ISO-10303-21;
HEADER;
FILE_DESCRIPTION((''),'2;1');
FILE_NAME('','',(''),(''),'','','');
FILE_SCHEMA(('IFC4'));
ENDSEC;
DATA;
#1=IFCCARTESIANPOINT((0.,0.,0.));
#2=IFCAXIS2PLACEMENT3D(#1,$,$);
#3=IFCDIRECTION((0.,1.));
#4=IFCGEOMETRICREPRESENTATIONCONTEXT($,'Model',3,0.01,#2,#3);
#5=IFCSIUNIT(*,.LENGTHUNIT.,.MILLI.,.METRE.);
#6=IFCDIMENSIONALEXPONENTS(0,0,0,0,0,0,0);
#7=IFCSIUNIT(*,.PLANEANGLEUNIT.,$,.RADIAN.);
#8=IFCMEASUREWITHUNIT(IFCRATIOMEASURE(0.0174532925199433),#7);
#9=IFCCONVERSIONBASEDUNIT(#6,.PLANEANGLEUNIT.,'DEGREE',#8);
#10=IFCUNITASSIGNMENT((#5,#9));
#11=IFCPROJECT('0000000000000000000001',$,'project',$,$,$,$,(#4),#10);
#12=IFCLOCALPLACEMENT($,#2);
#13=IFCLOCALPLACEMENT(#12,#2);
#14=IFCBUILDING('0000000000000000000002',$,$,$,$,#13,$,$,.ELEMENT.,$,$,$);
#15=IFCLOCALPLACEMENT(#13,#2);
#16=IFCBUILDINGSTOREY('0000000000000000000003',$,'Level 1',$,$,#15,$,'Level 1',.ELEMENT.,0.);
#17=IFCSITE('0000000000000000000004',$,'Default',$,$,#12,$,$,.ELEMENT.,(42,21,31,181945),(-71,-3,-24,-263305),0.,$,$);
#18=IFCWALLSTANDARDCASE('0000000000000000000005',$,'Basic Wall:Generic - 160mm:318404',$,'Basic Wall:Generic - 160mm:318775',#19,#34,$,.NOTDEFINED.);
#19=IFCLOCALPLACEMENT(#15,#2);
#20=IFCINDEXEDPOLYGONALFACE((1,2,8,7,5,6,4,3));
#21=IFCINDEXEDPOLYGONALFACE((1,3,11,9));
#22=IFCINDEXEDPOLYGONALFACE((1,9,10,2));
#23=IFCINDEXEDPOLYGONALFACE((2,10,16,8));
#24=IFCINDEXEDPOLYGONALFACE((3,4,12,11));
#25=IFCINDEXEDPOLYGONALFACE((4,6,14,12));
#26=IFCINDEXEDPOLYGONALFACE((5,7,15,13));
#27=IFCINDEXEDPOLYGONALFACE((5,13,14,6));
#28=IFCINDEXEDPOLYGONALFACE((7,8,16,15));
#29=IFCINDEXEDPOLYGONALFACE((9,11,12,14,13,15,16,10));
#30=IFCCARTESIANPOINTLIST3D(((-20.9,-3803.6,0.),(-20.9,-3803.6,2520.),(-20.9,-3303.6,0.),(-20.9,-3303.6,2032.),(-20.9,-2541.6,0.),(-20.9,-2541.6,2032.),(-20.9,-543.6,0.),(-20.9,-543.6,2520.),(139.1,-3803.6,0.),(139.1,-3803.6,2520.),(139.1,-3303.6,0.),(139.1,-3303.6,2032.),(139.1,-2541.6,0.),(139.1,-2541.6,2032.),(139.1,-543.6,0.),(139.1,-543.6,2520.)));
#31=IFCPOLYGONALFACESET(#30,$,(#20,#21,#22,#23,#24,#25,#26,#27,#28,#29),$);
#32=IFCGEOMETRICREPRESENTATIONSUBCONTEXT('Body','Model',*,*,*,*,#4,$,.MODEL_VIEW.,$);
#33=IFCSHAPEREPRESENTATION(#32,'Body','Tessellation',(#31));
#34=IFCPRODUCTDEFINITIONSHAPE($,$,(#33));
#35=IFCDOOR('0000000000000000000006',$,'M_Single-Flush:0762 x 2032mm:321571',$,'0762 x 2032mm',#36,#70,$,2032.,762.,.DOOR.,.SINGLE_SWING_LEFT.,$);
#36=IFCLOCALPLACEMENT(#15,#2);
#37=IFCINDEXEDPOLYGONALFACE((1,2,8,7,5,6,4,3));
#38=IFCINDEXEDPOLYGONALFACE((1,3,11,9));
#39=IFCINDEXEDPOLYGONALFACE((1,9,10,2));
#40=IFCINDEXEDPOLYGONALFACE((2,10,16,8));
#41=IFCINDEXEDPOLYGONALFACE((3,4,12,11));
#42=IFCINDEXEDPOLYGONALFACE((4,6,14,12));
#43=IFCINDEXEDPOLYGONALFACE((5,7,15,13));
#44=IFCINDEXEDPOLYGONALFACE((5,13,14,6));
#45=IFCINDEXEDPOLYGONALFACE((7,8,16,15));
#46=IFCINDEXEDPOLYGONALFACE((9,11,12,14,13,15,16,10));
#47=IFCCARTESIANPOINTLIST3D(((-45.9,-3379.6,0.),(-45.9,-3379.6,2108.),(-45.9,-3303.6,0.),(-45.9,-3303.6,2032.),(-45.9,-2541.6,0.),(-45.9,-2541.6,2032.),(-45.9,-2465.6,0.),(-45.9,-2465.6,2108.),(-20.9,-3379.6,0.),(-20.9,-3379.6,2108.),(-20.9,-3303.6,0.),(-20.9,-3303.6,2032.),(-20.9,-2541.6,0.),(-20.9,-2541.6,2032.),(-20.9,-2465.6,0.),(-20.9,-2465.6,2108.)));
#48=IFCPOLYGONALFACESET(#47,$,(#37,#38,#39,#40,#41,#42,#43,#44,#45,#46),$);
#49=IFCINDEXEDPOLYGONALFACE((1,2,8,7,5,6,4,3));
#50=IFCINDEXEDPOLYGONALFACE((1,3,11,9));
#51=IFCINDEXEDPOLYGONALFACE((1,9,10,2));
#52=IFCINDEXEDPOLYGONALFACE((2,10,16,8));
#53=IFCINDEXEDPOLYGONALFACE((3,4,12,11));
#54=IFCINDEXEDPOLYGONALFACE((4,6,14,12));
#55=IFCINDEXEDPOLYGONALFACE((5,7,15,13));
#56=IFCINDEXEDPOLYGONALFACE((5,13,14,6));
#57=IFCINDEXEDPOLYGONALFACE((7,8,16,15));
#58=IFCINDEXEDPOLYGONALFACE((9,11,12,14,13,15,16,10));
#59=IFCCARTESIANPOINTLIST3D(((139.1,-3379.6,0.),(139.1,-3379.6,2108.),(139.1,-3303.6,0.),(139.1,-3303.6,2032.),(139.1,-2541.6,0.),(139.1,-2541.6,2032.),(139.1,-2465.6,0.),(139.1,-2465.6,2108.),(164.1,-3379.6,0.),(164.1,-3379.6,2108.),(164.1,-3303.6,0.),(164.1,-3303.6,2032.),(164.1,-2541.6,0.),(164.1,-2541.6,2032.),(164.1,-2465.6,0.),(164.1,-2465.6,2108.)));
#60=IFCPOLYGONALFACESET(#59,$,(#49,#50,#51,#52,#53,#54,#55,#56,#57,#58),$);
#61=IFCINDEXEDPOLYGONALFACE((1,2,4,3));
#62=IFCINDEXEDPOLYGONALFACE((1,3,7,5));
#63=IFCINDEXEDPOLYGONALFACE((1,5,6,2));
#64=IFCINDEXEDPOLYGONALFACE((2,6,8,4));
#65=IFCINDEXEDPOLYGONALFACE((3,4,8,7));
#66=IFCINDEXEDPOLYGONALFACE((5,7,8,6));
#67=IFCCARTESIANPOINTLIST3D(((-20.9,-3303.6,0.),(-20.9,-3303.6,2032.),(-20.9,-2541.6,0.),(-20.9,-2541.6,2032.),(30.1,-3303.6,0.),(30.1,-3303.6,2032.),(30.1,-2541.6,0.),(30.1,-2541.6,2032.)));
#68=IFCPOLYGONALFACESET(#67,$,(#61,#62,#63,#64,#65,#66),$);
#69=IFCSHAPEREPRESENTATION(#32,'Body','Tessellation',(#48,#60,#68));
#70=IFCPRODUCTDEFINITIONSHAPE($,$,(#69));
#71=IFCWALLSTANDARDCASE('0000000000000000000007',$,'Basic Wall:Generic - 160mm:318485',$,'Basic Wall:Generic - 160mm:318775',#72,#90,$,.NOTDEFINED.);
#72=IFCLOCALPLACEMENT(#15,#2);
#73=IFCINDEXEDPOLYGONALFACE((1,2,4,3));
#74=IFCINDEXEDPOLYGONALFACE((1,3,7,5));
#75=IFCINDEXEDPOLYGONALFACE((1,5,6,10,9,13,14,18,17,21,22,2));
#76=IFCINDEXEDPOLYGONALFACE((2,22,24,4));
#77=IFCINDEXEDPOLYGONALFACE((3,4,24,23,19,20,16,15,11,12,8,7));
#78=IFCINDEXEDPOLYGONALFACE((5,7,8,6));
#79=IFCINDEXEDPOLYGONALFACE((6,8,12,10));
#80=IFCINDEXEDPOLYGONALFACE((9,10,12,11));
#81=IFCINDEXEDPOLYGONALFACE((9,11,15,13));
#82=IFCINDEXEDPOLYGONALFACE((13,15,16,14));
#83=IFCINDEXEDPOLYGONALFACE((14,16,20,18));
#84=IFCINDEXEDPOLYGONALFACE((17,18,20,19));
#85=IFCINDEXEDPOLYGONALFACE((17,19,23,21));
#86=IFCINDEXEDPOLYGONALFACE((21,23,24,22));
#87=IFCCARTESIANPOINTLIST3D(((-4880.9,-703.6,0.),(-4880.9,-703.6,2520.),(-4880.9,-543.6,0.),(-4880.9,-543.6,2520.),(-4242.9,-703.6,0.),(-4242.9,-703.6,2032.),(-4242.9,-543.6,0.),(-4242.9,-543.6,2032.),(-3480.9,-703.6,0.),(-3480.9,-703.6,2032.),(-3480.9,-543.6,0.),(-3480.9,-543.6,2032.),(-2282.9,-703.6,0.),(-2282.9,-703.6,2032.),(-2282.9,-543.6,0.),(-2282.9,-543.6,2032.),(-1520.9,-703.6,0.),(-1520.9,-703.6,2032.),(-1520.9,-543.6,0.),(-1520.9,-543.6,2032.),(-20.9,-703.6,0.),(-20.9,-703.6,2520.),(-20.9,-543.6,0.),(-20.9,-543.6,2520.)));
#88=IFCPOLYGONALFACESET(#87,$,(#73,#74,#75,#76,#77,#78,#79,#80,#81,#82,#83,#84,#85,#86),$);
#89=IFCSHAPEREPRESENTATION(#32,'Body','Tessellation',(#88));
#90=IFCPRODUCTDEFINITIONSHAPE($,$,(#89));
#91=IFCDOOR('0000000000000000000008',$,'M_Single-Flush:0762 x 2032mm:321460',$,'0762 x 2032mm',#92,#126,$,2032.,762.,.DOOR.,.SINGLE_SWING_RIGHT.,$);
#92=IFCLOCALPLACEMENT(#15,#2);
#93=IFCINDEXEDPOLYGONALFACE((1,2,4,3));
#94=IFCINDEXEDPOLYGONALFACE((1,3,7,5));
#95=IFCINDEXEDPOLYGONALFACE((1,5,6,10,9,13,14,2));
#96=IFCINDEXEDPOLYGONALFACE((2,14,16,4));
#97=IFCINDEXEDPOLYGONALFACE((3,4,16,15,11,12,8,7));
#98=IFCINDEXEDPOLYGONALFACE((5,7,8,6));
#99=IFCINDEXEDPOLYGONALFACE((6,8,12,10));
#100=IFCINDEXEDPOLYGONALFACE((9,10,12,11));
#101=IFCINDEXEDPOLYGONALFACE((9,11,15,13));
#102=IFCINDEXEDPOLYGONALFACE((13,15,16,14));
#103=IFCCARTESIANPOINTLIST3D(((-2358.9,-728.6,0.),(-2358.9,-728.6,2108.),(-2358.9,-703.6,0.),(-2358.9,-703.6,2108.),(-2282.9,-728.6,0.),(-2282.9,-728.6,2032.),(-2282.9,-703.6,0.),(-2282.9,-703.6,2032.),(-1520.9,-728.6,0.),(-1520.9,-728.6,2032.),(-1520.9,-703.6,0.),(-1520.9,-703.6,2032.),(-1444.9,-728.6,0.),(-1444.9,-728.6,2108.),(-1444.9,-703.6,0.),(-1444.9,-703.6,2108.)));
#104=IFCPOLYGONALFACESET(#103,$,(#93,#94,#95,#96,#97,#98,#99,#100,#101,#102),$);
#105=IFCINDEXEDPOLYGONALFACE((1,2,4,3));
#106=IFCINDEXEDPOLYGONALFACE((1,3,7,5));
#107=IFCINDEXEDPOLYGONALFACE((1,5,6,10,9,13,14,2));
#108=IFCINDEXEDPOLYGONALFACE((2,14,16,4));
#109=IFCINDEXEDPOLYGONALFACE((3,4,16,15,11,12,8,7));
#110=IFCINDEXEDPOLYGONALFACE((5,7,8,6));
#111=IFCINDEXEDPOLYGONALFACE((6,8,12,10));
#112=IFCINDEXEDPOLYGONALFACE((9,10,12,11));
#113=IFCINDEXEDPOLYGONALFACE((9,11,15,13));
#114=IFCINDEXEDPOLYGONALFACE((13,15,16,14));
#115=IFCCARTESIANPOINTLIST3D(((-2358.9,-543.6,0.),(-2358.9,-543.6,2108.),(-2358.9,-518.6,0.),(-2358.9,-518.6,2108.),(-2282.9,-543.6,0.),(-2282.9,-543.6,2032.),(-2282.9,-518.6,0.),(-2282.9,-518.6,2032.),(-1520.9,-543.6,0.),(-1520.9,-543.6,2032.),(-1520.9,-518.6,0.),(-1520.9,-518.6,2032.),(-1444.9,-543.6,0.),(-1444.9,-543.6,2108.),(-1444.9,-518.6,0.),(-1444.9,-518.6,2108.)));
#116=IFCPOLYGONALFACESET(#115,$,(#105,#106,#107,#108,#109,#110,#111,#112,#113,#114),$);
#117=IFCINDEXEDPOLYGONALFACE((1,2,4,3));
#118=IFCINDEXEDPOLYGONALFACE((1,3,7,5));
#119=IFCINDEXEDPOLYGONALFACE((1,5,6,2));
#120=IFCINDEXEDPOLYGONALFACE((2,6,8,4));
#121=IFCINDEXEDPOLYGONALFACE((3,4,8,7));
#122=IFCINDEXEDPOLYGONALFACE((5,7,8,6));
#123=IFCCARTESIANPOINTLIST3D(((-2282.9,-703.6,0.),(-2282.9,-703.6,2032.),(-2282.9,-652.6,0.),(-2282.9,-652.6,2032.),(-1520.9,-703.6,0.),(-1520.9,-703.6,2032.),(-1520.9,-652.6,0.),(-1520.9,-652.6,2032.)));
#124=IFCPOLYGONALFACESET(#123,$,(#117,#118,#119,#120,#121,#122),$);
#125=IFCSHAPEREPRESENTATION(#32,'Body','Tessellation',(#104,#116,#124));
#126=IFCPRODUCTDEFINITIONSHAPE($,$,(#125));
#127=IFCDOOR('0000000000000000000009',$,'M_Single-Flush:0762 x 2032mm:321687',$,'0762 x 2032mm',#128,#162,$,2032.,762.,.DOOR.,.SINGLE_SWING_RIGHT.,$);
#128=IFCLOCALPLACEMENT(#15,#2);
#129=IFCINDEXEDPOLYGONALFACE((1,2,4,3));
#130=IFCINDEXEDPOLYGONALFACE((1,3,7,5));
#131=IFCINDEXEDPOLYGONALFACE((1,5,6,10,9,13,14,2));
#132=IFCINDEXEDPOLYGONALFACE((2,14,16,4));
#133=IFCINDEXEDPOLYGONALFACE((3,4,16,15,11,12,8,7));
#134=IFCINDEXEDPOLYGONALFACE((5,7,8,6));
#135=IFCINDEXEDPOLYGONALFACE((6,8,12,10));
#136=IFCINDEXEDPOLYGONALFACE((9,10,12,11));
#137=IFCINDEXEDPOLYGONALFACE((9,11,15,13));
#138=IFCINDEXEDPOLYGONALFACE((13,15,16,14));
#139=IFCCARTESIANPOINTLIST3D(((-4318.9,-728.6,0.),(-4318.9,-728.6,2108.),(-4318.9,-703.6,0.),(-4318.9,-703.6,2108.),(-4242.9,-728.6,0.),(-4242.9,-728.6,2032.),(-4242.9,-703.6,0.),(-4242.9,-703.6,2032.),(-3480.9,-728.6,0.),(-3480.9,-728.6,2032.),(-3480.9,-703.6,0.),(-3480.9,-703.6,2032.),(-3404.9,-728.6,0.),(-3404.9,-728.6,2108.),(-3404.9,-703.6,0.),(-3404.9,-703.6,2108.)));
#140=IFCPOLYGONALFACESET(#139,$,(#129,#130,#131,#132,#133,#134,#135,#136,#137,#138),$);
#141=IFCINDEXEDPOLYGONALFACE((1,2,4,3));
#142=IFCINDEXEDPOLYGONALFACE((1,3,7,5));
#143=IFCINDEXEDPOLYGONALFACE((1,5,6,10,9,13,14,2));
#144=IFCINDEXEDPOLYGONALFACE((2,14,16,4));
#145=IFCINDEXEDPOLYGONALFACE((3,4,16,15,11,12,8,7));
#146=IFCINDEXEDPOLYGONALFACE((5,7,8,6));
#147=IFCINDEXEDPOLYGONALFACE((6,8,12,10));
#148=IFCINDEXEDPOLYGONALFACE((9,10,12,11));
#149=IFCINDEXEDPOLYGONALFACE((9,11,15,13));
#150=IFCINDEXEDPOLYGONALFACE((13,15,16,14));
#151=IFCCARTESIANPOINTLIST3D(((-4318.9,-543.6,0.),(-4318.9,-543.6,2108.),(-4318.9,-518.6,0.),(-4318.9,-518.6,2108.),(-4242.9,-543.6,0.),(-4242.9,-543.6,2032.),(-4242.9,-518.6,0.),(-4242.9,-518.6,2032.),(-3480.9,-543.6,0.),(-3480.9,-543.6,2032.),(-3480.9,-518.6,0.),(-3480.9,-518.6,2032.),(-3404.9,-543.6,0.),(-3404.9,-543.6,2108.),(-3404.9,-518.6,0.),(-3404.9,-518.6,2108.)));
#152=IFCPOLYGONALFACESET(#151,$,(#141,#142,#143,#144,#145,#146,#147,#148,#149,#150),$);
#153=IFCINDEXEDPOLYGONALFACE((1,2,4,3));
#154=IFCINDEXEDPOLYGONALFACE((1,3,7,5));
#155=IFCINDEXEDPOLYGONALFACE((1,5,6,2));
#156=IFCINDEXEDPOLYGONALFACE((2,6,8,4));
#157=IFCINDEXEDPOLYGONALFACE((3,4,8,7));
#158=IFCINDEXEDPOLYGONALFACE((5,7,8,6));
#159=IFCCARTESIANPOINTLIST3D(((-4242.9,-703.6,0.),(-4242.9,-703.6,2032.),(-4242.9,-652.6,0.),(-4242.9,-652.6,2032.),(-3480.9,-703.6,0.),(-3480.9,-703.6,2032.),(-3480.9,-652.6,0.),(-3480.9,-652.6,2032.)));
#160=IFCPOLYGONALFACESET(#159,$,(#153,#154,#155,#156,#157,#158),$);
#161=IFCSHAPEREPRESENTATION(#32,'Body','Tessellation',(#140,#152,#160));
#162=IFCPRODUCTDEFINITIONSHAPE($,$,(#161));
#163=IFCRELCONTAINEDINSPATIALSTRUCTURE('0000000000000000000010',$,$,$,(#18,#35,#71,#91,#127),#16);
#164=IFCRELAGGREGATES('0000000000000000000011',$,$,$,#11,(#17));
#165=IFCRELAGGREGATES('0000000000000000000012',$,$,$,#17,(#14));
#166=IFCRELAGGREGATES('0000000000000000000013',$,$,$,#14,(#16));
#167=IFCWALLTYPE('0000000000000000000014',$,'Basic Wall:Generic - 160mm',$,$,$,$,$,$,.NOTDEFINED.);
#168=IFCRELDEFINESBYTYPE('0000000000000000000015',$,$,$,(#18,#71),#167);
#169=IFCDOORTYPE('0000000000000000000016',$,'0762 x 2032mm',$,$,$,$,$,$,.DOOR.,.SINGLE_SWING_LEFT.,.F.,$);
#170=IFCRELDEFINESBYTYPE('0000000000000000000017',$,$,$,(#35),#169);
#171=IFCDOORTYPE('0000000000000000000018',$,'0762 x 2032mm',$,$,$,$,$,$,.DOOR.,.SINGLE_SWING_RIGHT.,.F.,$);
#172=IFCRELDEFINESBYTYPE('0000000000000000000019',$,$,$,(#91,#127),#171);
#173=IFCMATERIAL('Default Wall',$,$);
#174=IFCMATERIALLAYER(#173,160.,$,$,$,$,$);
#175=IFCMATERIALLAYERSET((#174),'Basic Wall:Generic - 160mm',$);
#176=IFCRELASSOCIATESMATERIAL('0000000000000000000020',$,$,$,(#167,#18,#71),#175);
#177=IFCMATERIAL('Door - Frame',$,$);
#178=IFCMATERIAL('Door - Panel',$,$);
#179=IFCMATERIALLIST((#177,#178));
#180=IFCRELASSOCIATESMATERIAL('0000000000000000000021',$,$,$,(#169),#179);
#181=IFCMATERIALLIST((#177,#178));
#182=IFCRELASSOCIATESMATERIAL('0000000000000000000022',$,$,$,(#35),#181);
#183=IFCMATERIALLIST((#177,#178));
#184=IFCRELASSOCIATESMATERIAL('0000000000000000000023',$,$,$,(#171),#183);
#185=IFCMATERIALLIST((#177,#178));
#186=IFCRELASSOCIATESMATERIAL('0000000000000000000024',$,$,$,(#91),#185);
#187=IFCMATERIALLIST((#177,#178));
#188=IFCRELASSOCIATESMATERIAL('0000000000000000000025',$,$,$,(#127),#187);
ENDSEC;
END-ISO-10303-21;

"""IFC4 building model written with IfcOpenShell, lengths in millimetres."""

from ifc_helpers import new_model, entity, si_unit, converted_unit, direction, frame, frame_2d, origin, place, context, subcontext, project, spatial, polyline, rectangle, outline, extrude, source, transform, mapped, material, material_list, layer, layer_set, layer_usage, type_object, type_shapes, element, fill, save


model = new_model("IFC4")

# Units and contexts
model_context = context("Model", 3, precision=0.01, world=origin(), true_north=direction((0.0, 1.0)))
body_context = subcontext(model_context, "Body", "Model", "MODEL_VIEW")
ifc_project = project(units=[si_unit("LENGTHUNIT", "METRE", prefix="MILLI"), converted_unit("PLANEANGLEUNIT", "DEGREE", entity("IfcRatioMeasure", 0.0174532925199433), si_unit("PLANEANGLEUNIT", "RADIAN"), dimensions=[0, 0, 0, 0, 0, 0, 0])], contexts=[model_context])

# Site, building, storey
site_placement = place(None, origin())
site = spatial("IfcSite", under=ifc_project, at=site_placement, Name="Default", CompositionType="ELEMENT", RefLatitude=(42, 21, 31, 181945), RefLongitude=(-71, -3, -24, -263305), RefElevation=0.0)
building_placement = place(site_placement, origin())
building = spatial("IfcBuilding", under=site, at=building_placement, CompositionType="ELEMENT")
storey_placement = place(building_placement, origin())
storey = spatial("IfcBuildingStorey", under=building, at=storey_placement, Name="Level 1", LongName="Level 1", CompositionType="ELEMENT", Elevation=0.0)

# Shared definitions
ifc_material_1 = material(Name="Default Wall")

# Shared definitions
ifc_layer_1 = layer(ifc_material_1, 160.0)
ifc_layer_set_1 = layer_set([ifc_layer_1], Name="Basic Wall:Generic - 160mm")
wall_type_1 = type_object("IfcWallType", Name="Basic Wall:Generic - 160mm", PredefinedType="NOTDEFINED", material=ifc_layer_set_1)

# Wall, opening, door
ifc_layer_usage_1 = layer_usage(ifc_layer_set_1, "AXIS2", "POSITIVE", -80.0)
wall_1_placement = place(storey_placement, frame((59.1, -3803.6, 0.0), z_axis=(0.0, 0.0, 1.0), x_axis=(0.0, 1.0, 0.0)))
wall_1 = element("IfcWallStandardCase", 1, at=wall_1_placement, inside=storey, type_object=wall_type_1, material=ifc_layer_usage_1, Name="Basic Wall:Generic - 160mm:318404", ObjectType="Basic Wall:Generic - 160mm:318775", PredefinedType="NOTDEFINED", context=body_context, shape_type="SweptSolid", body=[
    extrude(rectangle(XDim=3260.0, YDim=160.0, at=frame_2d((1630.0, 0.0), x_axis=(-1.0, 0.0))), origin(), (0.0, 0.0, 1.0), 2520.0),
])
opening_1_placement = place(wall_1_placement, frame((500.0, -80.0, 0.0)))
opening_1 = element("IfcOpeningElement", 2, at=opening_1_placement, cuts=wall_1, ObjectType="Opening", PredefinedType="OPENING", context=body_context, shape_type="SweptSolid", body=[
    extrude(rectangle(XDim=762.0, YDim=2032.0, at=frame_2d((1016.0, 381.0), x_axis=(0.0, -1.0))), frame((0.0, 0.0, 0.0), z_axis=(0.0, 1.0, 0.0), x_axis=(0.0, 0.0, 1.0)), (0.0, 0.0, 1.0), 160.0),
])
ifc_material_2 = material(Name="Door - Frame")
ifc_material_3 = material(Name="Door - Panel")
ifc_material_list_1 = material_list([ifc_material_2, ifc_material_3])
ifc_material_list_2 = material_list([ifc_material_2, ifc_material_3])
door_type_1 = type_object("IfcDoorType", Name="0762 x 2032mm", OperationType="SINGLE_SWING_LEFT", ParameterTakesPrecedence=False, PredefinedType="DOOR", material=ifc_material_list_2)
shared_shape_1 = source(origin(), body_context, "Body", "SweptSolid", [
    extrude(outline(polyline([(-457.0, -1073.0), (457.0, -1073.0), (457.0, 1035.0), (381.0, 1035.0), (381.0, -997.0), (-381.0, -997.0), (-381.0, 1035.0), (-457.0, 1035.0), (-457.0, -1073.0)])), frame((381.0, 185.0, 1035.0), z_axis=(0.0, -1.0, 0.0), x_axis=(-1.0, 0.0, 0.0)), (0.0, 0.0, 1.0), 25.0),
    extrude(outline(polyline([(-1073.0, -457.0), (1035.0, -457.0), (1035.0, -381.0), (-997.0, -381.0), (-997.0, 381.0), (1035.0, 381.0), (1035.0, 457.0), (-1073.0, 457.0), (-1073.0, -457.0)])), frame((381.0, 0.0, 1035.0), z_axis=(0.0, -1.0, 0.0), x_axis=(0.0, 0.0, -1.0)), (0.0, 0.0, 1.0), 25.0),
    extrude(rectangle(XDim=762.0, YDim=51.0, at=frame_2d((0.0, 0.0), x_axis=(1.0, 0.0))), frame((381.0, 134.5, 0.0)), (0.0, 0.0, 1.0), 2032.0),
])
type_shapes(door_type_1, [shared_shape_1])
door_1_placement = place(opening_1_placement, origin())
door_1 = element("IfcDoor", 3, at=door_1_placement, inside=storey, type_object=door_type_1, material=ifc_material_list_1, Name="M_Single-Flush:0762 x 2032mm:321571", ObjectType="0762 x 2032mm", OperationType="SINGLE_SWING_LEFT", OverallHeight=2032.0, OverallWidth=762.0, PredefinedType="DOOR", context=body_context, shape_type="MappedRepresentation", body=[
    mapped(shared_shape_1, transform((0.0, 0.0, 0.0), scale=1.0)),
])
fill(opening_1, door_1)

# Wall, openings, doors
ifc_layer_usage_2 = layer_usage(ifc_layer_set_1, "AXIS2", "POSITIVE", -80.0)
wall_2_placement = place(storey_placement, frame((-20.9, -623.6, 0.0), z_axis=(0.0, 0.0, 1.0), x_axis=(-1.0, 0.0, 0.0)))
wall_2 = element("IfcWallStandardCase", 4, at=wall_2_placement, inside=storey, type_object=wall_type_1, material=ifc_layer_usage_2, Name="Basic Wall:Generic - 160mm:318485", ObjectType="Basic Wall:Generic - 160mm:318775", PredefinedType="NOTDEFINED", context=body_context, shape_type="SweptSolid", body=[
    extrude(rectangle(XDim=4860.0, YDim=160.0, at=frame_2d((2430.0, 0.0), x_axis=(-1.0, 0.0))), origin(), (0.0, 0.0, 1.0), 2520.0),
])
opening_2_placement = place(wall_2_placement, frame((1500.0, -80.0, 0.0)))
opening_2 = element("IfcOpeningElement", 5, at=opening_2_placement, cuts=wall_2, ObjectType="Opening", PredefinedType="OPENING", context=body_context, shape_type="SweptSolid", body=[
    extrude(rectangle(XDim=762.0, YDim=2032.0, at=frame_2d((1016.0, 381.0), x_axis=(0.0, 1.0))), frame((0.0, 0.0, 0.0), z_axis=(0.0, 1.0, 0.0), x_axis=(0.0, 0.0, 1.0)), (0.0, 0.0, 1.0), 160.0),
])
opening_3_placement = place(wall_2_placement, frame((3460.0, -80.0, 0.0)))
opening_3 = element("IfcOpeningElement", 6, at=opening_3_placement, cuts=wall_2, ObjectType="Opening", PredefinedType="OPENING", context=body_context, shape_type="SweptSolid", body=[
    extrude(rectangle(XDim=762.0, YDim=2032.0, at=frame_2d((1016.0, 381.0), x_axis=(0.0, 1.0))), frame((0.0, 0.0, 0.0), z_axis=(0.0, 1.0, 0.0), x_axis=(0.0, 0.0, 1.0)), (0.0, 0.0, 1.0), 160.0),
])
ifc_material_list_3 = material_list([ifc_material_2, ifc_material_3])
ifc_material_list_4 = material_list([ifc_material_2, ifc_material_3])
door_type_2 = type_object("IfcDoorType", Name="0762 x 2032mm", OperationType="SINGLE_SWING_RIGHT", ParameterTakesPrecedence=False, PredefinedType="DOOR", material=ifc_material_list_4)
shared_shape_2 = source(origin(), body_context, "Body", "SweptSolid", [
    extrude(outline(polyline([(-457.0, -1073.0), (457.0, -1073.0), (457.0, 1035.0), (381.0, 1035.0), (381.0, -997.0), (-381.0, -997.0), (-381.0, 1035.0), (-457.0, 1035.0), (-457.0, -1073.0)])), frame((381.0, 160.0, 1035.0), z_axis=(0.0, 1.0, 0.0), x_axis=(1.0, 0.0, 0.0)), (0.0, 0.0, 1.0), 25.0),
    extrude(outline(polyline([(-1073.0, -457.0), (1035.0, -457.0), (1035.0, -381.0), (-997.0, -381.0), (-997.0, 381.0), (1035.0, 381.0), (1035.0, 457.0), (-1073.0, 457.0), (-1073.0, -457.0)])), frame((381.0, -25.0, 1035.0), z_axis=(0.0, 1.0, 0.0), x_axis=(0.0, 0.0, -1.0)), (0.0, 0.0, 1.0), 25.0),
    extrude(rectangle(XDim=51.0, YDim=762.0, at=frame_2d((0.0, 0.0), x_axis=(1.0, 0.0))), frame((381.0, 134.5, 0.0), z_axis=(0.0, 0.0, 1.0), x_axis=(0.0, 1.0, 0.0)), (0.0, 0.0, 1.0), 2032.0),
])
type_shapes(door_type_2, [shared_shape_2])
door_2_placement = place(opening_2_placement, origin())
door_2 = element("IfcDoor", 7, at=door_2_placement, inside=storey, type_object=door_type_2, material=ifc_material_list_3, Name="M_Single-Flush:0762 x 2032mm:321460", ObjectType="0762 x 2032mm", OperationType="SINGLE_SWING_RIGHT", OverallHeight=2032.0, OverallWidth=762.0, PredefinedType="DOOR", context=body_context, shape_type="MappedRepresentation", body=[
    mapped(shared_shape_2, transform((0.0, 0.0, 0.0), scale=1.0)),
])
fill(opening_2, door_2)
ifc_material_list_5 = material_list([ifc_material_2, ifc_material_3])
door_3_placement = place(opening_3_placement, origin())
door_3 = element("IfcDoor", 8, at=door_3_placement, inside=storey, type_object=door_type_2, material=ifc_material_list_5, Name="M_Single-Flush:0762 x 2032mm:321687", ObjectType="0762 x 2032mm", OperationType="SINGLE_SWING_RIGHT", OverallHeight=2032.0, OverallWidth=762.0, PredefinedType="DOOR", context=body_context, shape_type="MappedRepresentation", body=[
    mapped(shared_shape_2, transform((0.0, 0.0, 0.0), scale=1.0)),
])
fill(opening_3, door_3)

save(model, "model.ifc")
